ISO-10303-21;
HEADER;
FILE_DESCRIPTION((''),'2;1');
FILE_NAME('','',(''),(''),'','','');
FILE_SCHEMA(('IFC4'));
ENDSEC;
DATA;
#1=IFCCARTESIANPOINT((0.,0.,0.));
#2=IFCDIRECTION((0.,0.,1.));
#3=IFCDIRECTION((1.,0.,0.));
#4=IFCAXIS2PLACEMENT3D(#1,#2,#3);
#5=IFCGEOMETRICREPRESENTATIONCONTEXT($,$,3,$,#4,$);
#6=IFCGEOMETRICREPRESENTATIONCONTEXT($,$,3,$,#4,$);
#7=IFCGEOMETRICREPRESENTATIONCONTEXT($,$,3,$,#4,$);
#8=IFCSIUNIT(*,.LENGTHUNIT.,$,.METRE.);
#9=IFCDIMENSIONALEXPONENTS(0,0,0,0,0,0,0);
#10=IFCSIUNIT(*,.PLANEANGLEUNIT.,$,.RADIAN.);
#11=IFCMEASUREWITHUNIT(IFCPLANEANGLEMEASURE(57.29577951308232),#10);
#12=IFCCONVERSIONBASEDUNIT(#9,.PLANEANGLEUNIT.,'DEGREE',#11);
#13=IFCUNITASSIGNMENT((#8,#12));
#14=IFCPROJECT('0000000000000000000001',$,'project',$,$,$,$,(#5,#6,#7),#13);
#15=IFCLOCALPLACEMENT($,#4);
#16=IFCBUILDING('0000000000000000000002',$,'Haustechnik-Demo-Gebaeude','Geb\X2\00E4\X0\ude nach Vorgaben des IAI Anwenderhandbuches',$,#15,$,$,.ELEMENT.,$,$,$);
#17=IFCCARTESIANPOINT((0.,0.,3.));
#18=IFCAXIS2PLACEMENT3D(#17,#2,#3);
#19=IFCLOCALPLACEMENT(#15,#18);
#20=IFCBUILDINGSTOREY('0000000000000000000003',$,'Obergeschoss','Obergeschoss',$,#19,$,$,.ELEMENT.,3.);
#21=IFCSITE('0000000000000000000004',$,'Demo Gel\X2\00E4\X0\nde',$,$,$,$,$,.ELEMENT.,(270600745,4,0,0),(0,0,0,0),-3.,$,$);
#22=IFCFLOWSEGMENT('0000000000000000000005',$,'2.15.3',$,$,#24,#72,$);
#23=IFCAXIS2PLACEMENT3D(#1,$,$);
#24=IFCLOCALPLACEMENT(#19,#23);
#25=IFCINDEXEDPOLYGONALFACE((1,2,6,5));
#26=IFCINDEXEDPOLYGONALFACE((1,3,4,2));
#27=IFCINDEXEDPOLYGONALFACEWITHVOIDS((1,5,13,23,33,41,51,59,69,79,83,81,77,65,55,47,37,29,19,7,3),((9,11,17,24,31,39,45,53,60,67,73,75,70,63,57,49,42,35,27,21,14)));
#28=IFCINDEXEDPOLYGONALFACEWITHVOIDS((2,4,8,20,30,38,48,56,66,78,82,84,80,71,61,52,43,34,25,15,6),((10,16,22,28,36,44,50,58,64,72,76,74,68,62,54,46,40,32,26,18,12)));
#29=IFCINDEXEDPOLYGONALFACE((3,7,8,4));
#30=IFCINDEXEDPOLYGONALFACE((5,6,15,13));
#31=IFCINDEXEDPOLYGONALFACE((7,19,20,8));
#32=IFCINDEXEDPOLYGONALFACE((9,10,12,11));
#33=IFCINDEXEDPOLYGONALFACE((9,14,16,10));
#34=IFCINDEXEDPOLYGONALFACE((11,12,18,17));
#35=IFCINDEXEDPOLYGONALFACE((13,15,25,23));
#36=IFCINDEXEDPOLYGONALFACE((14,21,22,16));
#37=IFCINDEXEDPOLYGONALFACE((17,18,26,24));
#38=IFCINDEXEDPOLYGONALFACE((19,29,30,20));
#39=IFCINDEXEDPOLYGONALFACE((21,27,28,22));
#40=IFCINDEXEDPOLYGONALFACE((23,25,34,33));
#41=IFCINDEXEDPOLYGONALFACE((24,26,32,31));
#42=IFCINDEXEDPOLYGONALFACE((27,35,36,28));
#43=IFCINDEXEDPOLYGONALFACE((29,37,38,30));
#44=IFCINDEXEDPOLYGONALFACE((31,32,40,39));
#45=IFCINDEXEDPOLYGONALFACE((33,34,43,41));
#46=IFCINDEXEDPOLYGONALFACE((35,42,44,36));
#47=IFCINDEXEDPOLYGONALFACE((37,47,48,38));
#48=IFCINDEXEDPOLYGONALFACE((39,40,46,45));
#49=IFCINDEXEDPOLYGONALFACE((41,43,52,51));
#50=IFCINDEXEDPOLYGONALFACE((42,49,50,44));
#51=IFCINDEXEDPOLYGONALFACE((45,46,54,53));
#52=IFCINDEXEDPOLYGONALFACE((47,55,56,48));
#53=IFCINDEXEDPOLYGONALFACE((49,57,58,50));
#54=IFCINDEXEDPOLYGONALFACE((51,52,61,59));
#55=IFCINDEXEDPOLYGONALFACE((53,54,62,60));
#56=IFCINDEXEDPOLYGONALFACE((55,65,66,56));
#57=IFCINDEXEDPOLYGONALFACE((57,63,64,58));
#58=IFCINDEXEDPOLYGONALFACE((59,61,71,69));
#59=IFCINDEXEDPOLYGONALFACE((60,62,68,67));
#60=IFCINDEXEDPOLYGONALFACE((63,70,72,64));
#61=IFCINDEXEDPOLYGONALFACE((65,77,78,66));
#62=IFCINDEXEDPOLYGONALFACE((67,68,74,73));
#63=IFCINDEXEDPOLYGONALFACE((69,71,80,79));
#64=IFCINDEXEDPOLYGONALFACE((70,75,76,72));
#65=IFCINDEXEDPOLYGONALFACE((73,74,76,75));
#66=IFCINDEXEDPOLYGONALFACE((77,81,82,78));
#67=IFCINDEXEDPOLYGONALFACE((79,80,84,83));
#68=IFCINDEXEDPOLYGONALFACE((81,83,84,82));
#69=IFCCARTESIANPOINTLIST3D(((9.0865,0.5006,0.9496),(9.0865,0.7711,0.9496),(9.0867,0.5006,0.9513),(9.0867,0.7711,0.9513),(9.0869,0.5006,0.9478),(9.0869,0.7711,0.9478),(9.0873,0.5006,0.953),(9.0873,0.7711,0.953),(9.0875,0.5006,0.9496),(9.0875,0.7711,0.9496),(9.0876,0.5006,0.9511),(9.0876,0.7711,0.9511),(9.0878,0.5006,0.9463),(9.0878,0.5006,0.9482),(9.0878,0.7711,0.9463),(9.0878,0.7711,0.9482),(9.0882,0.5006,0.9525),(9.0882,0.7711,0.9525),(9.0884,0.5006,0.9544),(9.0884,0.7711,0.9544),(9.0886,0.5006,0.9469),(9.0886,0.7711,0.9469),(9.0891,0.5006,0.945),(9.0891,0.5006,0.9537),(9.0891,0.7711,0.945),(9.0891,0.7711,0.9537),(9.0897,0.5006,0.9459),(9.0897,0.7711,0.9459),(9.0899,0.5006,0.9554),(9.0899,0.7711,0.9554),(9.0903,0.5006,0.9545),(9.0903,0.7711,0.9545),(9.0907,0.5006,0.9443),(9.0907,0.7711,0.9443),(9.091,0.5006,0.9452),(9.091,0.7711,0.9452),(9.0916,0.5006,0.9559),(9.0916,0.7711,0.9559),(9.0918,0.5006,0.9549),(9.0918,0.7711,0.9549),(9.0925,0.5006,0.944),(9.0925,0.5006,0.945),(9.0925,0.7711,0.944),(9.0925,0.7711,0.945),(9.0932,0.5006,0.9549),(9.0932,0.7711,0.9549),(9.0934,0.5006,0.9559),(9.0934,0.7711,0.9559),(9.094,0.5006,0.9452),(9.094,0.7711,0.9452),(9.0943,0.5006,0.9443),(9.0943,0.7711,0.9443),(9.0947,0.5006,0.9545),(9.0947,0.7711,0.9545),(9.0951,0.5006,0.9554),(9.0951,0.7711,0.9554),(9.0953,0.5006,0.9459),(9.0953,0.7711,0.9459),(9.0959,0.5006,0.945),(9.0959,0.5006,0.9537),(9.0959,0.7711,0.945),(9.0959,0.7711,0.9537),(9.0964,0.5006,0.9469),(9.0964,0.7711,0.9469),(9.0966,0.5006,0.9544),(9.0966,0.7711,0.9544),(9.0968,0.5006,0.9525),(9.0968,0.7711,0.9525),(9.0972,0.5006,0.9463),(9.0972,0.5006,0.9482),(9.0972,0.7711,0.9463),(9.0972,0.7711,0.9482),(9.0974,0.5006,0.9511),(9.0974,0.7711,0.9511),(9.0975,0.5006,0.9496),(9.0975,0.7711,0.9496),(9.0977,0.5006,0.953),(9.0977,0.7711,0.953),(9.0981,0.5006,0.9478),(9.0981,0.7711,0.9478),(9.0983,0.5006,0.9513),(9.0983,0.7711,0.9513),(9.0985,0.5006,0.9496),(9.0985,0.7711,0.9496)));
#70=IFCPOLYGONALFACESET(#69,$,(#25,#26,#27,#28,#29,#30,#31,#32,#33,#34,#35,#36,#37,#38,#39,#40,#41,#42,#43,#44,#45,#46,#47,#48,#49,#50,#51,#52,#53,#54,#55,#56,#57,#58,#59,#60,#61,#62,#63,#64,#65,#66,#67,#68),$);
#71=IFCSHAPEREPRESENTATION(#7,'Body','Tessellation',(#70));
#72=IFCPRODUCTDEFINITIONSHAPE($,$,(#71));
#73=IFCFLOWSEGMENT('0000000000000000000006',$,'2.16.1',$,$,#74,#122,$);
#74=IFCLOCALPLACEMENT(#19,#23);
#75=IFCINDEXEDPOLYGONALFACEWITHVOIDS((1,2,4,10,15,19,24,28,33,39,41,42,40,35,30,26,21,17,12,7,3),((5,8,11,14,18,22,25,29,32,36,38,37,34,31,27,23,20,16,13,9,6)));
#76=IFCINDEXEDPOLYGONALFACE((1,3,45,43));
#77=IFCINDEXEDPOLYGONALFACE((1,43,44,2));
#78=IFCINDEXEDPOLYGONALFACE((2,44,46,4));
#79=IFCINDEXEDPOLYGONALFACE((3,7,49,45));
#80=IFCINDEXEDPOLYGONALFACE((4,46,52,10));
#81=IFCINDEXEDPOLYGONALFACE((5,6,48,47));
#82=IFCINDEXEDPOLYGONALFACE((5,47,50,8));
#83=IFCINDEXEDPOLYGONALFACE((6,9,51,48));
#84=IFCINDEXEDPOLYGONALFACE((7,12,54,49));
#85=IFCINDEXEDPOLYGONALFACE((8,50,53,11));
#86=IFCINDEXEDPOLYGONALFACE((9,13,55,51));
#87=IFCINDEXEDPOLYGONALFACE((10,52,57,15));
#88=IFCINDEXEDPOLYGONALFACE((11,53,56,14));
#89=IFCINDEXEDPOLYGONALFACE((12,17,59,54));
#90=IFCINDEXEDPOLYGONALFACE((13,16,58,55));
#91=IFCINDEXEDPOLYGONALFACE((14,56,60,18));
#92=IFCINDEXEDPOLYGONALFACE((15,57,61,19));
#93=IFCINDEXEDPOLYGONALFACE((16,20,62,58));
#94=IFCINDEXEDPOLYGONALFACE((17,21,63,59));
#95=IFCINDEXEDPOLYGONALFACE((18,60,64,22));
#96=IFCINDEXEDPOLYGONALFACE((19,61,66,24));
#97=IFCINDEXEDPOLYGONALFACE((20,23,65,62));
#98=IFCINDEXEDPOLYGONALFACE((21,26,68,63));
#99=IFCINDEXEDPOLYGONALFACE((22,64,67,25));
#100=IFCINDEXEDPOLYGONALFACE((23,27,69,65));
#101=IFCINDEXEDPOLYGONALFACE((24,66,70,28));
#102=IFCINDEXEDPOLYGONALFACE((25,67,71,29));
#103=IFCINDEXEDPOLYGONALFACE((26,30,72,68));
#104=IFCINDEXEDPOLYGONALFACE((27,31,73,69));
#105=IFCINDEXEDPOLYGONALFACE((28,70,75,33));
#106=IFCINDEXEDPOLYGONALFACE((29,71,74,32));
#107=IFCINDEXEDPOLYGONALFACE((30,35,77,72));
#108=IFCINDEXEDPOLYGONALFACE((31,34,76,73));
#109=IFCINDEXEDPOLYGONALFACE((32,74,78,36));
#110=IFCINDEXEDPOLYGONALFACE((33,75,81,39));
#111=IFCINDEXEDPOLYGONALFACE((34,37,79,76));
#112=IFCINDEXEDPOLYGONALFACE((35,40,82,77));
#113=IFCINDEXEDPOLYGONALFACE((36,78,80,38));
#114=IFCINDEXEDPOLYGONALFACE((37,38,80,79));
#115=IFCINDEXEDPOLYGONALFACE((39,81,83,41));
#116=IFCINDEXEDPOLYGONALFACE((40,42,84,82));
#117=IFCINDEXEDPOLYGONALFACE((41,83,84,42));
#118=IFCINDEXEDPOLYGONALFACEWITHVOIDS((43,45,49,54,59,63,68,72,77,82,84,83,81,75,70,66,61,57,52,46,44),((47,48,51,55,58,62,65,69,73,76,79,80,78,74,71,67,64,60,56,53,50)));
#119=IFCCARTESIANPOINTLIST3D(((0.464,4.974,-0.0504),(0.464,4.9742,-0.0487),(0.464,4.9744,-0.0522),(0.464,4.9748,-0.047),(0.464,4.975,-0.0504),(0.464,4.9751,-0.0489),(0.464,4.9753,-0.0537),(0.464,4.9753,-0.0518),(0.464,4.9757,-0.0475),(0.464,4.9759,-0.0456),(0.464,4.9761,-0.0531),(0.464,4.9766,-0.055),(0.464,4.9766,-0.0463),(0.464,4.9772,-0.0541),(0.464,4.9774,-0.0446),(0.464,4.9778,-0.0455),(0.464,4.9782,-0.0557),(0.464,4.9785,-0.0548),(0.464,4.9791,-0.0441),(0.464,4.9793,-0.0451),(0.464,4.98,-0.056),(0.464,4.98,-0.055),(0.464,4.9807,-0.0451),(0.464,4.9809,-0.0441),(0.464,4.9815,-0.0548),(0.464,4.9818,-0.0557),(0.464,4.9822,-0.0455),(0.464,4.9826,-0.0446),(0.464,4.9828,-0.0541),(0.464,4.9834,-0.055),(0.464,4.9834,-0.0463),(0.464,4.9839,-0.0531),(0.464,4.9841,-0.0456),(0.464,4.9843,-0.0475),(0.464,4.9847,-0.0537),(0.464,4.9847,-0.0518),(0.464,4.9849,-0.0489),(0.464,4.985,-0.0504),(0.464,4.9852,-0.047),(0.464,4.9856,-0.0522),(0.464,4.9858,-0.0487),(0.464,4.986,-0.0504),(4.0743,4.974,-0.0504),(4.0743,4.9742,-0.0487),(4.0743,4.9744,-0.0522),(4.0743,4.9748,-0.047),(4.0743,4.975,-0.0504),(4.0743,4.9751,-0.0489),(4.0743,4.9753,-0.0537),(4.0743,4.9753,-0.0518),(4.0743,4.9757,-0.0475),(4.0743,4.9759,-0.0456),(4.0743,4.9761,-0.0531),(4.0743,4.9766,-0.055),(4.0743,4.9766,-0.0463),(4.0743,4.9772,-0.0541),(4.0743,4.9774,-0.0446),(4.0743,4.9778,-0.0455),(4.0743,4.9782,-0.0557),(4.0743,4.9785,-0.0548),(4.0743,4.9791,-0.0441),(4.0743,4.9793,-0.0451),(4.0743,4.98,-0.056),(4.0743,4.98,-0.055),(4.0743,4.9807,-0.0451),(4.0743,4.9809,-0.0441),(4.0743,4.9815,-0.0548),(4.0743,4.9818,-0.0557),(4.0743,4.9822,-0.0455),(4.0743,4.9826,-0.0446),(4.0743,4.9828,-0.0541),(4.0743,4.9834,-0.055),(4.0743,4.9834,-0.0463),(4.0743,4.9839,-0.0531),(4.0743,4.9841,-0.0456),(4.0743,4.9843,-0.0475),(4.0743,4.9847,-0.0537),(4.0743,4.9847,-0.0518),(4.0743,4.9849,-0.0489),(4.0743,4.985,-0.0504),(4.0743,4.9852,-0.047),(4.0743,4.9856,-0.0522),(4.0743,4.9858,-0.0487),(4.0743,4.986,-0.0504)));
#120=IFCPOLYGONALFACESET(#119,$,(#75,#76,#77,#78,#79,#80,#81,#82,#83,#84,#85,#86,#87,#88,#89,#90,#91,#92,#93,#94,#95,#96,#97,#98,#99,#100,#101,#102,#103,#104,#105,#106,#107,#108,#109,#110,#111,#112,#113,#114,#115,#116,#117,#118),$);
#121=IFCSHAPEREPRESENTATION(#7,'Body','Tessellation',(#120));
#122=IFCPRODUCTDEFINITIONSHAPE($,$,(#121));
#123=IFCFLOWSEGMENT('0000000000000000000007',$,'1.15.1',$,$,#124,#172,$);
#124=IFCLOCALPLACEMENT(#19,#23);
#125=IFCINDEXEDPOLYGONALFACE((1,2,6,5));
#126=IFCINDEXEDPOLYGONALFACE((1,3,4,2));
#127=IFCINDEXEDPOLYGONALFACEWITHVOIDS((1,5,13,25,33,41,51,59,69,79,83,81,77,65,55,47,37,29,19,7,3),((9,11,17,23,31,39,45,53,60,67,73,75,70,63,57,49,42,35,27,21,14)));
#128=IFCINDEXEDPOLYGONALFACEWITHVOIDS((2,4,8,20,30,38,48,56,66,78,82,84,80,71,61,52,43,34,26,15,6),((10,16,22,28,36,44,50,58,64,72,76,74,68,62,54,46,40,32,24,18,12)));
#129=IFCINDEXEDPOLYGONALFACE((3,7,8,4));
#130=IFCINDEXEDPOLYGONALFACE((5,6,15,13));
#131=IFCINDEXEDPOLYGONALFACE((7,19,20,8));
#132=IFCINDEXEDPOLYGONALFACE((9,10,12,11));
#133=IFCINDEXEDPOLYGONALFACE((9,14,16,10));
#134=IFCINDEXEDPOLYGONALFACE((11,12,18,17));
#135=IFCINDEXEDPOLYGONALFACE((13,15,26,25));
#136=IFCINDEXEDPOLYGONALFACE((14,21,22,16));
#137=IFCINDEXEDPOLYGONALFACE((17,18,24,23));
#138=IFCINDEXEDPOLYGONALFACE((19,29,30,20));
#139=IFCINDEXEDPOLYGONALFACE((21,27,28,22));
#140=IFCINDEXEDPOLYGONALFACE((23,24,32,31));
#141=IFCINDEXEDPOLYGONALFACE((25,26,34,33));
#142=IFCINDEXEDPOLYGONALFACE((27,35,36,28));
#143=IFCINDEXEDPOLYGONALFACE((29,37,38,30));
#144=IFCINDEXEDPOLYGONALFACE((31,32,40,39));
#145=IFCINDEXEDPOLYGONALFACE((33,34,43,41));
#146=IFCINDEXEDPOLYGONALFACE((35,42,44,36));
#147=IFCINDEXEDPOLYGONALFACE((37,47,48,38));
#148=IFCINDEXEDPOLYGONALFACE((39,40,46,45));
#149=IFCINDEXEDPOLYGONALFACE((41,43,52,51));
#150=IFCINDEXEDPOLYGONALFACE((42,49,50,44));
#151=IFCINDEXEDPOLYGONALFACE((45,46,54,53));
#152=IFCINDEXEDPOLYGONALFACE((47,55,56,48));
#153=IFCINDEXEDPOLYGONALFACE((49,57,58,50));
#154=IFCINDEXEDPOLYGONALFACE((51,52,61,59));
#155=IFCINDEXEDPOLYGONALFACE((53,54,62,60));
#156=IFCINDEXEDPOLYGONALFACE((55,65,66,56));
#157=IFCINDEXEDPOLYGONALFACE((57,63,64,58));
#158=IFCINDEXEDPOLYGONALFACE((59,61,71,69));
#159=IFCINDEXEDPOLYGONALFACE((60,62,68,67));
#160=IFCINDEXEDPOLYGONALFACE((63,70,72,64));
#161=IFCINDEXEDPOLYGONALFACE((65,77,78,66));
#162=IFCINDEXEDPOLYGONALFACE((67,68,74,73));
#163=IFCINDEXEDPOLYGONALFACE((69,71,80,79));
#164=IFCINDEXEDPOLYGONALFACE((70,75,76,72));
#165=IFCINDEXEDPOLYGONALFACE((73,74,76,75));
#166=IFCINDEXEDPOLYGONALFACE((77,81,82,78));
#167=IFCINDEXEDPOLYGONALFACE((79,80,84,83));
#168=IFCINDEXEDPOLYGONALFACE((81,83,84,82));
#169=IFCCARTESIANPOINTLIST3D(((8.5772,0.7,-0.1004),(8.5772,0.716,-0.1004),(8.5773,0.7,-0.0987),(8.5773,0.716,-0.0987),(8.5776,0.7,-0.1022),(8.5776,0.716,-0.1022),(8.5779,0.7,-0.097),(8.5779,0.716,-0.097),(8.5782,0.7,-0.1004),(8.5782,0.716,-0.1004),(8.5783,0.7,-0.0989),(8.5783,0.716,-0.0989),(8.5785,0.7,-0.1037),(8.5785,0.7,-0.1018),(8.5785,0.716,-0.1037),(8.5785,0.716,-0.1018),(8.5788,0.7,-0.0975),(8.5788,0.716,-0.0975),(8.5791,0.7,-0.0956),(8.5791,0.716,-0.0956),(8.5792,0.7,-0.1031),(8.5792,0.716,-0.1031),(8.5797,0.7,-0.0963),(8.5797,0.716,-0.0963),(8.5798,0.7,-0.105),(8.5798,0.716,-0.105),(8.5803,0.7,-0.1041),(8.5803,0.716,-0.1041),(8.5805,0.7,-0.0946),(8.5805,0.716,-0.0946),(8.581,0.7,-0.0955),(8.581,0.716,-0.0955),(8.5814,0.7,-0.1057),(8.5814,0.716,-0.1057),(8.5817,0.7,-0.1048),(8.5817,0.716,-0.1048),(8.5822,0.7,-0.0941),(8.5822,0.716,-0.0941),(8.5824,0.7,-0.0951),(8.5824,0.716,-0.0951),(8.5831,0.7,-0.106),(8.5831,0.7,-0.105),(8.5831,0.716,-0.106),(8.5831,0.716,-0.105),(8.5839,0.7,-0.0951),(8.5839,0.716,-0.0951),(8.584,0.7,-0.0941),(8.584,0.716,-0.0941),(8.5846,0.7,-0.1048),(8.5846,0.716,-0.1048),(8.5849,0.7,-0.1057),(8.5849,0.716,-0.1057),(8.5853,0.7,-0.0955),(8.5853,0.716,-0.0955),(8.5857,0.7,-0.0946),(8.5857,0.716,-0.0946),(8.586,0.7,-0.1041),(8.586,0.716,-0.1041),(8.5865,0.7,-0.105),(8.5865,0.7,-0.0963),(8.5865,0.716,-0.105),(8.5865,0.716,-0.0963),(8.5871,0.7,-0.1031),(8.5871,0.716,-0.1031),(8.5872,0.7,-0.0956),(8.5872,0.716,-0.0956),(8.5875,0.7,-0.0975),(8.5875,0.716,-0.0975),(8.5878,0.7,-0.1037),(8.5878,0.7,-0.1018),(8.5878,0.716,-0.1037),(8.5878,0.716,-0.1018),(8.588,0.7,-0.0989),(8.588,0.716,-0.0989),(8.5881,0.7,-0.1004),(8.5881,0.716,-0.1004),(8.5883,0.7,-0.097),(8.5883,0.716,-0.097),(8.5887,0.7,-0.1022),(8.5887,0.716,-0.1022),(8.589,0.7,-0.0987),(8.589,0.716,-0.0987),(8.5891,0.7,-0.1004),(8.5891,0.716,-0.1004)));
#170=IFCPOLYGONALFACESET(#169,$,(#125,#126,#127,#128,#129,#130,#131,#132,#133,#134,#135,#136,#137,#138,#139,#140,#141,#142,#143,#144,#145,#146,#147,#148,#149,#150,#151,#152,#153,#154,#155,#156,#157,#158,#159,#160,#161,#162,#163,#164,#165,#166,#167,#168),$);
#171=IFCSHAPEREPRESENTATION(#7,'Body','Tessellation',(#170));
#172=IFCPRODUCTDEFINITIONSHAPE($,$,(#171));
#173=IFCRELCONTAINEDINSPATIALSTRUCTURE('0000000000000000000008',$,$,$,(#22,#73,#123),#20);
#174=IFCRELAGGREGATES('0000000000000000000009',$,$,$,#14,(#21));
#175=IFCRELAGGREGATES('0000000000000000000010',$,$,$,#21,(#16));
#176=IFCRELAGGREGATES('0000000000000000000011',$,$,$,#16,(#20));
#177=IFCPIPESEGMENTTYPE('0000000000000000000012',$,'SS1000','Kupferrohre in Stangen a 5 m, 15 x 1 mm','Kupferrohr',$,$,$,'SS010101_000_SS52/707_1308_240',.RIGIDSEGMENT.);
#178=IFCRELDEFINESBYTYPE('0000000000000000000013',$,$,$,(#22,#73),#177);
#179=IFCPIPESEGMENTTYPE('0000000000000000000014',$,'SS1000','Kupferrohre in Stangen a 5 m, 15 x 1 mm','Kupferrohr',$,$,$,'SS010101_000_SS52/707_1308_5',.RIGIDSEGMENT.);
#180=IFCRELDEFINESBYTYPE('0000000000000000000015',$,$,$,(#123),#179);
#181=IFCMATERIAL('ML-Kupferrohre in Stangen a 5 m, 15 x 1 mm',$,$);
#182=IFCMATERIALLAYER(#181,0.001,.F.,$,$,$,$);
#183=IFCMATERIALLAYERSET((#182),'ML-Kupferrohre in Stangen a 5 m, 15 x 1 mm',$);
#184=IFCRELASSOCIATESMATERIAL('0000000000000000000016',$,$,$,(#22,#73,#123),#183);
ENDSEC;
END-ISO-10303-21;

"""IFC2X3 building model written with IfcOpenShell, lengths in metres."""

from ifc_helpers import new_model, entity, si_unit, converted_unit, frame, origin_with_axes, origin_2d_with_axis, place, context, project, spatial, hollow_circle, extrude, material, layer, layer_set, layer_usage, type_object, element, save


model = new_model("IFC2X3")

# Units and contexts
context_of_model_1 = context(None, 3, world=origin_with_axes())
context_of_model_2 = context(None, 3, world=origin_with_axes())
context_of_model_3 = context(None, 3, world=origin_with_axes())
ifc_project = project(units=[si_unit("LENGTHUNIT", "METRE"), converted_unit("PLANEANGLEUNIT", "DEGREE", entity("IfcPlaneAngleMeasure", 57.29577951308232), si_unit("PLANEANGLEUNIT", "RADIAN"), dimensions=[0, 0, 0, 0, 0, 0, 0])], contexts=[context_of_model_1, context_of_model_2, context_of_model_3])

# Site, building, storey
site = spatial("IfcSite", under=ifc_project, Name="Demo Gelände", CompositionType="ELEMENT", RefLatitude=(270600745, 4, 0, 0), RefLongitude=(0, 0, 0, 0), RefElevation=-3.0)
building_placement = place(None, origin_with_axes())
building = spatial("IfcBuilding", under=site, at=building_placement, Name="Haustechnik-Demo-Gebaeude", Description="Gebäude nach Vorgaben des IAI Anwenderhandbuches", CompositionType="ELEMENT")
storey_placement = place(building_placement, frame((0.0, 0.0, 3.0), z_axis=(0.0, 0.0, 1.0), x_axis=(1.0, 0.0, 0.0)))
storey = spatial("IfcBuildingStorey", under=building, at=storey_placement, Name="Obergeschoss", Description="Obergeschoss", CompositionType="ELEMENT", Elevation=3.0)

# Flow segments
ifc_material = material(Name="ML-Kupferrohre in Stangen a 5 m, 15 x 1 mm")
ifc_layer = layer(ifc_material, 0.001, ventilated=False)
ifc_layer_set = layer_set([ifc_layer], Name="ML-Kupferrohre in Stangen a 5 m, 15 x 1 mm")
ifc_layer_usage = layer_usage(ifc_layer_set, "AXIS2", "POSITIVE", 0.0)
pipe_segment_type_1 = type_object("IfcPipeSegmentType", Name="SS1000", Description="Kupferrohre in Stangen a 5 m, 15 x 1 mm", ApplicableOccurrence="Kupferrohr", ElementType="SS010101_000_SS52/707_1308_240", PredefinedType="RIGIDSEGMENT")
flow_segment_1_placement = place(storey_placement, frame((9.0925, 0.5006, 0.95), z_axis=(0.0, 1.0, 0.0), x_axis=(0.0, 0.0, -1.0)))
element("IfcFlowSegment", 1, at=flow_segment_1_placement, inside=storey, type_object=pipe_segment_type_1, material=ifc_layer_usage, Name="2.15.3", context=context_of_model_3, shape_type="SweptSolid", body=[
    extrude(hollow_circle(Radius=0.006, WallThickness=0.001, at=origin_2d_with_axis()), origin_with_axes(), (0.0, 0.0, 1.0), 0.2705),
])
flow_segment_2_placement = place(storey_placement, frame((4.0743, 4.98, -0.05), z_axis=(-1.0, 0.0, 0.0), x_axis=(0.0, 0.0, -1.0)))
element("IfcFlowSegment", 2, at=flow_segment_2_placement, inside=storey, type_object=pipe_segment_type_1, material=ifc_layer_usage, Name="2.16.1", context=context_of_model_3, shape_type="SweptSolid", body=[
    extrude(hollow_circle(Radius=0.006, WallThickness=0.001, at=origin_2d_with_axis()), origin_with_axes(), (0.0, 0.0, 1.0), 3.6103),
])
pipe_segment_type_2 = type_object("IfcPipeSegmentType", Name="SS1000", Description="Kupferrohre in Stangen a 5 m, 15 x 1 mm", ApplicableOccurrence="Kupferrohr", ElementType="SS010101_000_SS52/707_1308_5", PredefinedType="RIGIDSEGMENT")
flow_segment_3_placement = place(storey_placement, frame((8.5831, 0.716, -0.1), z_axis=(0.0, -1.0, 0.0), x_axis=(0.0, 0.0, -1.0)))
element("IfcFlowSegment", 3, at=flow_segment_3_placement, inside=storey, type_object=pipe_segment_type_2, material=ifc_layer_usage, Name="1.15.1", context=context_of_model_3, shape_type="SweptSolid", body=[
    extrude(hollow_circle(Radius=0.006, WallThickness=0.001, at=origin_2d_with_axis()), origin_with_axes(), (0.0, 0.0, 1.0), 0.016),
])

save(model, "model.ifc")
